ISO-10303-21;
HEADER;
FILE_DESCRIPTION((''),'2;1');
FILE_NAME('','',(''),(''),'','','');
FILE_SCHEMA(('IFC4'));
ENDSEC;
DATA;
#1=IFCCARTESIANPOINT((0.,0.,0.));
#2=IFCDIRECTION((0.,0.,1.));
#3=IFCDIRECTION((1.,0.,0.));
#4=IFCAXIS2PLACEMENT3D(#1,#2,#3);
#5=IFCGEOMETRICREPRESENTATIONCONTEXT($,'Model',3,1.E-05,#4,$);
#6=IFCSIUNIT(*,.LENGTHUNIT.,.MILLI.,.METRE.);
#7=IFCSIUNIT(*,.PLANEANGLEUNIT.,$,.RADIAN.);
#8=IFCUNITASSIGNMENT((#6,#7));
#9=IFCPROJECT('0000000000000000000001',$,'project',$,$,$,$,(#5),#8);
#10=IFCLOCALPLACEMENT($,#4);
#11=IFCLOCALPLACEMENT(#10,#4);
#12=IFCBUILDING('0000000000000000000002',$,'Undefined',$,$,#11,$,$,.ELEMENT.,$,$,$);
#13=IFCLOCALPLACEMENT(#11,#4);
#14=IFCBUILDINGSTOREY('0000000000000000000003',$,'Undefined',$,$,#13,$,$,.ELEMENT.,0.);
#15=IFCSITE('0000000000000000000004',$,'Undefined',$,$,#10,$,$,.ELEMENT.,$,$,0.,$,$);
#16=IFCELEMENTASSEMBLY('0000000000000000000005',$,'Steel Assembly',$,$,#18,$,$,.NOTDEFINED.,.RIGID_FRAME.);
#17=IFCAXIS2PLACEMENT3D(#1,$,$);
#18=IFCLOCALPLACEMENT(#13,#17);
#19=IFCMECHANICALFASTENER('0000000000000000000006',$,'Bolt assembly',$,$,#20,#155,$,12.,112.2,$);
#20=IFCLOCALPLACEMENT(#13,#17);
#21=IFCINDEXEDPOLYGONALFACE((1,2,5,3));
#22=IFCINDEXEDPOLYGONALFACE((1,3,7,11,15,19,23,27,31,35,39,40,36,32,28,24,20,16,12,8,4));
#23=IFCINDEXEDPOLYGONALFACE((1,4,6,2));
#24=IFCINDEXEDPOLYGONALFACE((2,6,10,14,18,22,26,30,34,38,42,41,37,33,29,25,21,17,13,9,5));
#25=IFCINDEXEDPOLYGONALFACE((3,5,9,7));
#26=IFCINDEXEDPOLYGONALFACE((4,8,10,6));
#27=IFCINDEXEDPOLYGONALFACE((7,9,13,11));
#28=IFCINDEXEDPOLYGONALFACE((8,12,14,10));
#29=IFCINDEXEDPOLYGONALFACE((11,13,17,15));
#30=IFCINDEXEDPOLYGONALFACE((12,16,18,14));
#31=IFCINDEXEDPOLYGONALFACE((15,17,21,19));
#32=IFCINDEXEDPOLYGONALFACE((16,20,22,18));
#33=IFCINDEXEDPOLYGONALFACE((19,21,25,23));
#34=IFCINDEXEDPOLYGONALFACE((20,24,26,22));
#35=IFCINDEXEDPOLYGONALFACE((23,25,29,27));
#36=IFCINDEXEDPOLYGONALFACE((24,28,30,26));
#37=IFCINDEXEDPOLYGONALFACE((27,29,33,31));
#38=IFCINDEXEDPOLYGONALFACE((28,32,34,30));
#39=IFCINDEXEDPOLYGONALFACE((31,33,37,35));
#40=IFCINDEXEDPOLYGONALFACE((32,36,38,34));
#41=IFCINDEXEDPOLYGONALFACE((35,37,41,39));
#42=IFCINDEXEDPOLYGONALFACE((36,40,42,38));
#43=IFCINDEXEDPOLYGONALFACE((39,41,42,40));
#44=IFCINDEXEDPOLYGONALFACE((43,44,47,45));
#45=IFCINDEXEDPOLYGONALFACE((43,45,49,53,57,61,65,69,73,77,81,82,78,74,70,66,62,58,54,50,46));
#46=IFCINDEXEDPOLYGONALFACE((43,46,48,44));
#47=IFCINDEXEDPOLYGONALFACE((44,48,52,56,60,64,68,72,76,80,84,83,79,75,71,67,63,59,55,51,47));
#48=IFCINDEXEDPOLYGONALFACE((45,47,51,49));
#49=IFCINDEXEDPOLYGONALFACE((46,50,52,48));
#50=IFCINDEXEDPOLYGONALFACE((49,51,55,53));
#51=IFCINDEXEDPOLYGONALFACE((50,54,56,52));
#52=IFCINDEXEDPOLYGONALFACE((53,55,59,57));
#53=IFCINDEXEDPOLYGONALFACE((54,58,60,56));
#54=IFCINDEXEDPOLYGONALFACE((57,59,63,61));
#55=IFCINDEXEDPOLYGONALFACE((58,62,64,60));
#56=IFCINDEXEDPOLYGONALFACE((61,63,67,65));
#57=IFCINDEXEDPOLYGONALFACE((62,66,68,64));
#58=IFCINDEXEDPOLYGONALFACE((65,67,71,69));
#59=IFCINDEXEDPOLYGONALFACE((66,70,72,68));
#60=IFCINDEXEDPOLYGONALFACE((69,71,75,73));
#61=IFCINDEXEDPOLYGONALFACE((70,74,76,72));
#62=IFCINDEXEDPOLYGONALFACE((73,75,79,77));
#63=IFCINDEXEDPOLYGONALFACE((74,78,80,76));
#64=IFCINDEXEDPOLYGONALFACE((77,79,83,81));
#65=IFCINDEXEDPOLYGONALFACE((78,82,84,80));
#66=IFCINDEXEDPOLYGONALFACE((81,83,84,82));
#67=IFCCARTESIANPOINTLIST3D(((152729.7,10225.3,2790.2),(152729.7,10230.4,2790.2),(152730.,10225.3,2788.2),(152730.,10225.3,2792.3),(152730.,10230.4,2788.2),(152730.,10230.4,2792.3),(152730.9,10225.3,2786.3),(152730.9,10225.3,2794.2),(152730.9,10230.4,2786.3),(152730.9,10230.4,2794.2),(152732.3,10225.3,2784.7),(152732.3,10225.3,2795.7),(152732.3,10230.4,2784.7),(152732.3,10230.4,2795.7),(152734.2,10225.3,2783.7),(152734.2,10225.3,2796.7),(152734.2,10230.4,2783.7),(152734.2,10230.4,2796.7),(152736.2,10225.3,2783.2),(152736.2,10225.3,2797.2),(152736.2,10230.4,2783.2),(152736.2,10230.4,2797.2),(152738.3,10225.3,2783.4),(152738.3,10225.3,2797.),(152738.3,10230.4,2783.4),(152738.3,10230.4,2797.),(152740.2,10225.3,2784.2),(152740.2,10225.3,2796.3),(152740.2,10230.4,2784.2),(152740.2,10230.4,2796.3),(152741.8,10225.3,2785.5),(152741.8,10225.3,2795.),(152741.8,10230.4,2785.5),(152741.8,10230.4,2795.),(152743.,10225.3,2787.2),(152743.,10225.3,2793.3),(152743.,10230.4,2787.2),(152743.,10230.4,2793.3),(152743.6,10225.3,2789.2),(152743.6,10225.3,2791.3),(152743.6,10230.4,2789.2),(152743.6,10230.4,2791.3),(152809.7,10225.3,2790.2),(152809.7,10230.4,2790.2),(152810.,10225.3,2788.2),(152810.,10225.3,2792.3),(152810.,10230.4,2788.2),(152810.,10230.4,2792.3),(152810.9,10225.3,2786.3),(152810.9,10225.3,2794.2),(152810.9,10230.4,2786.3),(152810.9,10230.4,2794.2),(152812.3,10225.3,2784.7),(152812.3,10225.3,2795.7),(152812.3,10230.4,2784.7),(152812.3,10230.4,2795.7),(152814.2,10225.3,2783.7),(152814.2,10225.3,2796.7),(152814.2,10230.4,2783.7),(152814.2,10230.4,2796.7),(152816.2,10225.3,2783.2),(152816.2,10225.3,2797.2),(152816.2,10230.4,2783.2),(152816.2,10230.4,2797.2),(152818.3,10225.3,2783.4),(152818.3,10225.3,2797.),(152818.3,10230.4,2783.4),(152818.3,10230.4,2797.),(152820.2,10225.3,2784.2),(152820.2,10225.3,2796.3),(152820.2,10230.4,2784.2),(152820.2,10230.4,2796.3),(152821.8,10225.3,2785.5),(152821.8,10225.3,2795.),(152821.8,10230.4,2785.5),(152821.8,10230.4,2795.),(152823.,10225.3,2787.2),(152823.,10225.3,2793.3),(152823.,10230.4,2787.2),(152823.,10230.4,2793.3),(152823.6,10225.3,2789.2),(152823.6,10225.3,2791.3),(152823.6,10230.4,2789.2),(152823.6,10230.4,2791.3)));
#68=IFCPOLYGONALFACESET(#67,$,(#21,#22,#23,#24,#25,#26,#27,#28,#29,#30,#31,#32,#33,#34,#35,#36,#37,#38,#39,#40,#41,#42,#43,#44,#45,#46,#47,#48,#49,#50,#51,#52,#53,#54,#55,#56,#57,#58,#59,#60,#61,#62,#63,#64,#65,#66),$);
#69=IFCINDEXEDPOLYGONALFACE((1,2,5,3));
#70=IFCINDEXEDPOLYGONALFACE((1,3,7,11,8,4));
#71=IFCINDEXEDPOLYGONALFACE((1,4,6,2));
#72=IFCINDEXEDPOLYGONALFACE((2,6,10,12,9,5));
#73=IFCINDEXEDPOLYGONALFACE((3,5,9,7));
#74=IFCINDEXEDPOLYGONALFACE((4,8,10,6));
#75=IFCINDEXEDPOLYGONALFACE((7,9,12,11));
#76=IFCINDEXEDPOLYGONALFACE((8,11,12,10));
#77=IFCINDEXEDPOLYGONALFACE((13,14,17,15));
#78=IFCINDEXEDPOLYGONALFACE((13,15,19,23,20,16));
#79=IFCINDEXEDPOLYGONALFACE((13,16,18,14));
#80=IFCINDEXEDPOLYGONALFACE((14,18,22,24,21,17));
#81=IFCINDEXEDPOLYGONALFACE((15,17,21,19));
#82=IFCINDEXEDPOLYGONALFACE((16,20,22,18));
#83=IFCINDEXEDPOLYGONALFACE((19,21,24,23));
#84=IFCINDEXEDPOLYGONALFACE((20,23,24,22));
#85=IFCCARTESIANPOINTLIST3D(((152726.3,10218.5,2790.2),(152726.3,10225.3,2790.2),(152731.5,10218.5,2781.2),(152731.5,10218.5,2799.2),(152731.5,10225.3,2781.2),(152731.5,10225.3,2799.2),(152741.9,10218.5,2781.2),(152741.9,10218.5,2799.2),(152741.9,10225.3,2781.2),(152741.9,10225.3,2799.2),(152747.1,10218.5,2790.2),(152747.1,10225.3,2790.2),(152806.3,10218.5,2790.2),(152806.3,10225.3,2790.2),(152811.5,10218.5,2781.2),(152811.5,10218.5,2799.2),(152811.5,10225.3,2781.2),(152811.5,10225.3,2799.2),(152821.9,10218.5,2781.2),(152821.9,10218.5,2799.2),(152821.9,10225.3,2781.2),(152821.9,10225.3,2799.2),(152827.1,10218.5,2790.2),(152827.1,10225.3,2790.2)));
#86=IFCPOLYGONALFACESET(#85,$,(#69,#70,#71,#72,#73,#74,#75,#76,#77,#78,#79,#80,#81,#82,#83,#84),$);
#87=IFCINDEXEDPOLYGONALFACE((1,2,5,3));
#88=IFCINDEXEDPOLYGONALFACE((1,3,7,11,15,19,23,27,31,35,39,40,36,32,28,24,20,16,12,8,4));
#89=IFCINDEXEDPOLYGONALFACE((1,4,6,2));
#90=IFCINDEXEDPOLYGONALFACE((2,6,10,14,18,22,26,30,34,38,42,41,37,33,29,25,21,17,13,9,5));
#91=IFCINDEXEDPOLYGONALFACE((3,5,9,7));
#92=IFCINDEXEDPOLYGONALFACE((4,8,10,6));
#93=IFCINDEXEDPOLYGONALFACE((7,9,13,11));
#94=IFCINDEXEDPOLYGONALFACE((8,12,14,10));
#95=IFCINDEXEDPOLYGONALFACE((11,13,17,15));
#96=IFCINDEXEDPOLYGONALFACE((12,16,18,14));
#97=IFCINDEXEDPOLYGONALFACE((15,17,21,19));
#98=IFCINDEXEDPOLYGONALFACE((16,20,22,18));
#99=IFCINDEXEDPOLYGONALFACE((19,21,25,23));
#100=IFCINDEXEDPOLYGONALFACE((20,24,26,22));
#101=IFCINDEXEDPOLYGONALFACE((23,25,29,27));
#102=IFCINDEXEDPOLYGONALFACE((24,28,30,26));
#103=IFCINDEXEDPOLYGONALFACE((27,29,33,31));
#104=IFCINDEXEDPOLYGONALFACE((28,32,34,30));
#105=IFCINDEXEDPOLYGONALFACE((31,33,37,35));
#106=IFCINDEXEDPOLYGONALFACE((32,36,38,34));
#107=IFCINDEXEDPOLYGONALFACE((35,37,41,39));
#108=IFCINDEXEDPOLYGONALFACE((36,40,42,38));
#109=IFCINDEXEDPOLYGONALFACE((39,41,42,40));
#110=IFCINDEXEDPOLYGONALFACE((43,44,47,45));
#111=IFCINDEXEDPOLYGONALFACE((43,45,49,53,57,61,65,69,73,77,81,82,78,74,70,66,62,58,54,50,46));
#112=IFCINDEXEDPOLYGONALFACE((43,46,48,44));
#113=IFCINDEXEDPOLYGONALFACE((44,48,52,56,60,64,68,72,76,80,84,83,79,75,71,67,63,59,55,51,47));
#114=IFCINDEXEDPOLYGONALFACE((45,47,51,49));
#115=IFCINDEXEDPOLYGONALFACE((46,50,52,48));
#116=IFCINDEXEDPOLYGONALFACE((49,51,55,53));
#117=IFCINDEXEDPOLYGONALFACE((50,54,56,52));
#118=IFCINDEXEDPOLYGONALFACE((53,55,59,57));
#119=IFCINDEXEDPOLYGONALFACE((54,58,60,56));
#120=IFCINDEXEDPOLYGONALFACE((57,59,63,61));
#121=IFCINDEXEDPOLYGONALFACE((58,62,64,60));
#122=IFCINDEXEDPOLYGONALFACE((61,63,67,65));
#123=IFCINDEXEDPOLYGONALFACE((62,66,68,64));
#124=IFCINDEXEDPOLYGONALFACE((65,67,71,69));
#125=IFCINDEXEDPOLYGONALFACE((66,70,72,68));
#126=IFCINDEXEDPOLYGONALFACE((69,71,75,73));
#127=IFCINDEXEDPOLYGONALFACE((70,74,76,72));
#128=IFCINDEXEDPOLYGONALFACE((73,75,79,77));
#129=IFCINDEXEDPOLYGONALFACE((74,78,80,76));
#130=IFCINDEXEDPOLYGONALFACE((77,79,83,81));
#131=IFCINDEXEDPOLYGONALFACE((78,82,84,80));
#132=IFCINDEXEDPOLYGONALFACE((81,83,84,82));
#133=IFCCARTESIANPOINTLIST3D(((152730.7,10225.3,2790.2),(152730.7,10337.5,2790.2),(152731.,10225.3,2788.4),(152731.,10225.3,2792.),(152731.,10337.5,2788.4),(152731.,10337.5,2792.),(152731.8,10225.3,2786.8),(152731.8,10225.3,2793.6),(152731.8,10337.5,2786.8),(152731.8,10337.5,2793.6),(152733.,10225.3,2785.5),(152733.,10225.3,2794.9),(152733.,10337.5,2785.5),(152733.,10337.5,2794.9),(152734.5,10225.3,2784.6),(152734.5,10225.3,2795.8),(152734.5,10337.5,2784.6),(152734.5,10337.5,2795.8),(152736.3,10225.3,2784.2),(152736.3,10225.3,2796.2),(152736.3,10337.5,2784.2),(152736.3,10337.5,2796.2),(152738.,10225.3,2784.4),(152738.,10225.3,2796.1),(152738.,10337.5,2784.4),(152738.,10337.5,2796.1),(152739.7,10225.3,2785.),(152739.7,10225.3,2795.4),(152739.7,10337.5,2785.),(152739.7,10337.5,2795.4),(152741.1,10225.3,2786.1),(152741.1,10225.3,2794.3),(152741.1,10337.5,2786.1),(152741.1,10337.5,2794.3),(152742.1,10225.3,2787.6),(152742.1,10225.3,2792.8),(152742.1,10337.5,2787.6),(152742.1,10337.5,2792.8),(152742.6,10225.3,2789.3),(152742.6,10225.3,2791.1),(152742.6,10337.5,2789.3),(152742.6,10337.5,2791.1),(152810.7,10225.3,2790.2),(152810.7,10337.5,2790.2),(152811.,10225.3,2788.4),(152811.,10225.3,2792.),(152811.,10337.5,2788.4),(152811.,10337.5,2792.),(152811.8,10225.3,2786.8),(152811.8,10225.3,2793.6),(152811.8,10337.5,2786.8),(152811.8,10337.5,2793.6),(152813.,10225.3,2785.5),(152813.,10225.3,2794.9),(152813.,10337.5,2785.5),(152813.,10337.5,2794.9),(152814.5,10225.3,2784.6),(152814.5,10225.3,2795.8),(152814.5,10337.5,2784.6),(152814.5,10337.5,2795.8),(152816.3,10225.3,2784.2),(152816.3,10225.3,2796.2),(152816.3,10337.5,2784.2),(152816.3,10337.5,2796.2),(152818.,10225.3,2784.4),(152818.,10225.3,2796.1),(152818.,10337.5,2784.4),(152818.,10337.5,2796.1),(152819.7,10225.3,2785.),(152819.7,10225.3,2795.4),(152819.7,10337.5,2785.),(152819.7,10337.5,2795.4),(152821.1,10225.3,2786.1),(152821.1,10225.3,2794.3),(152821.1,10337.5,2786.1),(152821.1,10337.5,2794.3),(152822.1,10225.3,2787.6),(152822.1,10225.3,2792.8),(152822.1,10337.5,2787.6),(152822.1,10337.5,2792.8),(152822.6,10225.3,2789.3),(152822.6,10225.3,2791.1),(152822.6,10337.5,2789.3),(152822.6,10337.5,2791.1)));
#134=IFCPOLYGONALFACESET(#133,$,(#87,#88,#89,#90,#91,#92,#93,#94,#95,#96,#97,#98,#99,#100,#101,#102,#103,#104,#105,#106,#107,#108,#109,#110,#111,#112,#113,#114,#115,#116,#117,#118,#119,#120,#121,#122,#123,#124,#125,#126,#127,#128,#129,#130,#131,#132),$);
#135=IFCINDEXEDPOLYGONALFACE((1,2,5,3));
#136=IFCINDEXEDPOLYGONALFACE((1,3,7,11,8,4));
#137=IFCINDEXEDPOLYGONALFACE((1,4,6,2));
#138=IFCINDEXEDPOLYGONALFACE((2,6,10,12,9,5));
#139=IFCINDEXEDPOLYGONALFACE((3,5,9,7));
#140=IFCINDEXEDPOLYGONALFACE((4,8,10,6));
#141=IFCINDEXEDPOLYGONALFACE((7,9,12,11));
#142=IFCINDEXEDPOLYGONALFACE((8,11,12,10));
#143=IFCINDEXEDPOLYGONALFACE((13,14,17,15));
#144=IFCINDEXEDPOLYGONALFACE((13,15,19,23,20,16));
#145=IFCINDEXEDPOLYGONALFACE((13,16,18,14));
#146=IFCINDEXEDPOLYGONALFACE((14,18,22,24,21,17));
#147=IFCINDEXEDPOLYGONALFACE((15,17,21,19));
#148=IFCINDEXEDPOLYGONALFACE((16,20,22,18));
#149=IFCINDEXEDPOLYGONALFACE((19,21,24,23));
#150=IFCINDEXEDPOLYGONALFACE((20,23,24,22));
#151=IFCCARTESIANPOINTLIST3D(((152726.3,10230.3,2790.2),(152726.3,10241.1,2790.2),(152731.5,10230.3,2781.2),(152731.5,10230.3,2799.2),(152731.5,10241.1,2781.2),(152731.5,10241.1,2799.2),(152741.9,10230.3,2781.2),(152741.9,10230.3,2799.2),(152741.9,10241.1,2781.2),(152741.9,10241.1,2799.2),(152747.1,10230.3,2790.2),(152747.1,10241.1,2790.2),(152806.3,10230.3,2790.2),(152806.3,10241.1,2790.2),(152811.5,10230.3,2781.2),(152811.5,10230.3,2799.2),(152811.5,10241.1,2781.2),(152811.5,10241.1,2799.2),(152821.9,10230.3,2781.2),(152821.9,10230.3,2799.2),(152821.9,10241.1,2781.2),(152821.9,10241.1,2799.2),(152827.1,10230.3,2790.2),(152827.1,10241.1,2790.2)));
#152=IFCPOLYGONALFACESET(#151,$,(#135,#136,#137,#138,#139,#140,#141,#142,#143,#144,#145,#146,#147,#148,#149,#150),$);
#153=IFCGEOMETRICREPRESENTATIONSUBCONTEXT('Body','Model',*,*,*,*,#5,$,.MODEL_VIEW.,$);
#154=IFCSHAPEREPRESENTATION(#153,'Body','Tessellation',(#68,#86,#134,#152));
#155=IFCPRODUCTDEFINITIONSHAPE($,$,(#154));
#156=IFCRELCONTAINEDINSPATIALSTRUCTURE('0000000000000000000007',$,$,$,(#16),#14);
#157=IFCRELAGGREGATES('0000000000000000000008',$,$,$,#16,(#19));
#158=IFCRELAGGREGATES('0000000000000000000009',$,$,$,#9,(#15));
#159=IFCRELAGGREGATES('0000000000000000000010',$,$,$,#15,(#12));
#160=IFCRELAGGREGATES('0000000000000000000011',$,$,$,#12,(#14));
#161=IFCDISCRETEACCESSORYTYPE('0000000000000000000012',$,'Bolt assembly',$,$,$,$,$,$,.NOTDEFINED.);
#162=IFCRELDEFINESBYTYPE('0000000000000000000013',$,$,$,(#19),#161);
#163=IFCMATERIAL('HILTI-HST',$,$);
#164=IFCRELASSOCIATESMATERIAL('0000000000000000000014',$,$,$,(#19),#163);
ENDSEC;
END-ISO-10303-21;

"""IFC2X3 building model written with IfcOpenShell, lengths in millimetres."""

from ifc_helpers import new_model, si_unit, frame, origin_with_axes, origin_2d_with_axis, place, context, subcontext, project, spatial, polyline, circle, outline, extrude, source, transform, mapped, material, type_object, element, aggregate, save


model = new_model("IFC2X3")

# Units and contexts
model_context = context("Model", 3, precision=1e-05, world=origin_with_axes())
body_context = subcontext(model_context, "Body", "Model", "MODEL_VIEW")
ifc_project = project(units=[si_unit("LENGTHUNIT", "METRE", prefix="MILLI"), si_unit("PLANEANGLEUNIT", "RADIAN")], contexts=[model_context])

# Site, building, storey
site_placement = place(None, origin_with_axes())
site = spatial("IfcSite", under=ifc_project, at=site_placement, Name="Undefined", CompositionType="ELEMENT", RefElevation=0.0)
building_placement = place(site_placement, origin_with_axes())
building = spatial("IfcBuilding", under=site, at=building_placement, Name="Undefined", CompositionType="ELEMENT")
storey_placement = place(building_placement, origin_with_axes())
storey = spatial("IfcBuildingStorey", under=building, at=storey_placement, Name="Undefined", CompositionType="ELEMENT", Elevation=0.0)

# Element assembly
assembly_1_placement = place(storey_placement, origin_with_axes())
assembly_1 = element("IfcElementAssembly", 1, at=assembly_1_placement, inside=storey, Name="Steel Assembly", AssemblyPlace="NOTDEFINED", PredefinedType="RIGID_FRAME")

# Mechanical fastener
ifc_material_1 = material(Name="HILTI-HST")
discrete_accessory_type_1 = type_object("IfcDiscreteAccessoryType", Name="Bolt assembly")
shared_shape_1 = source(origin_with_axes(), body_context, "Body", "SweptSolid", [
    extrude(circle(Radius=7.0, at=origin_2d_with_axis()), frame((0.0, 0.0, 0.0), z_axis=(0.0, 1.0, 0.0), x_axis=(1.0, 0.0, 0.0)), (0.0, 0.0, 1.0), 5.1),
    extrude(outline(polyline([(10.4, 0.0), (5.2, 9.0), (-5.2, 9.0), (-10.4, 0.0), (-5.2, -9.0), (5.2, -9.0), (10.4, 0.0)])), frame((0.0, -6.8, 0.0), z_axis=(0.0, 1.0, 0.0), x_axis=(1.0, 0.0, 0.0)), (0.0, 0.0, 1.0), 6.8),
    extrude(circle(Radius=6.0, at=origin_2d_with_axis()), frame((0.0, 0.0, 0.0), z_axis=(0.0, 1.0, 0.0), x_axis=(1.0, 0.0, 0.0)), (0.0, 0.0, 1.0), 112.2),
    extrude(outline(polyline([(10.4, 0.0), (5.2, 9.0), (-5.2, 9.0), (-10.4, 0.0), (-5.2, -9.0), (5.2, -9.0), (10.4, 0.0)])), frame((0.0, 5.0, 0.0), z_axis=(0.0, 1.0, 0.0), x_axis=(1.0, 0.0, 0.0)), (0.0, 0.0, 1.0), 10.8),
])
mechanical_fastener_1_placement = place(assembly_1_placement, frame((152816.7, 10225.3, 2790.2), z_axis=(0.0, 0.0, -1.0), x_axis=(-1.0, 0.0, 0.0)))
mechanical_fastener_1 = element("IfcMechanicalFastener", 2, at=mechanical_fastener_1_placement, type_object=discrete_accessory_type_1, material=ifc_material_1, Name="Bolt assembly", NominalDiameter=12.0, NominalLength=112.2, context=body_context, shape_type="MappedRepresentation", body=[
    mapped(shared_shape_1, transform((0.0, 0.0, 0.0))),
    mapped(shared_shape_1, transform((80.0, 0.0, 0.0))),
])
aggregate(assembly_1, [mechanical_fastener_1])

save(model, "model.ifc")
